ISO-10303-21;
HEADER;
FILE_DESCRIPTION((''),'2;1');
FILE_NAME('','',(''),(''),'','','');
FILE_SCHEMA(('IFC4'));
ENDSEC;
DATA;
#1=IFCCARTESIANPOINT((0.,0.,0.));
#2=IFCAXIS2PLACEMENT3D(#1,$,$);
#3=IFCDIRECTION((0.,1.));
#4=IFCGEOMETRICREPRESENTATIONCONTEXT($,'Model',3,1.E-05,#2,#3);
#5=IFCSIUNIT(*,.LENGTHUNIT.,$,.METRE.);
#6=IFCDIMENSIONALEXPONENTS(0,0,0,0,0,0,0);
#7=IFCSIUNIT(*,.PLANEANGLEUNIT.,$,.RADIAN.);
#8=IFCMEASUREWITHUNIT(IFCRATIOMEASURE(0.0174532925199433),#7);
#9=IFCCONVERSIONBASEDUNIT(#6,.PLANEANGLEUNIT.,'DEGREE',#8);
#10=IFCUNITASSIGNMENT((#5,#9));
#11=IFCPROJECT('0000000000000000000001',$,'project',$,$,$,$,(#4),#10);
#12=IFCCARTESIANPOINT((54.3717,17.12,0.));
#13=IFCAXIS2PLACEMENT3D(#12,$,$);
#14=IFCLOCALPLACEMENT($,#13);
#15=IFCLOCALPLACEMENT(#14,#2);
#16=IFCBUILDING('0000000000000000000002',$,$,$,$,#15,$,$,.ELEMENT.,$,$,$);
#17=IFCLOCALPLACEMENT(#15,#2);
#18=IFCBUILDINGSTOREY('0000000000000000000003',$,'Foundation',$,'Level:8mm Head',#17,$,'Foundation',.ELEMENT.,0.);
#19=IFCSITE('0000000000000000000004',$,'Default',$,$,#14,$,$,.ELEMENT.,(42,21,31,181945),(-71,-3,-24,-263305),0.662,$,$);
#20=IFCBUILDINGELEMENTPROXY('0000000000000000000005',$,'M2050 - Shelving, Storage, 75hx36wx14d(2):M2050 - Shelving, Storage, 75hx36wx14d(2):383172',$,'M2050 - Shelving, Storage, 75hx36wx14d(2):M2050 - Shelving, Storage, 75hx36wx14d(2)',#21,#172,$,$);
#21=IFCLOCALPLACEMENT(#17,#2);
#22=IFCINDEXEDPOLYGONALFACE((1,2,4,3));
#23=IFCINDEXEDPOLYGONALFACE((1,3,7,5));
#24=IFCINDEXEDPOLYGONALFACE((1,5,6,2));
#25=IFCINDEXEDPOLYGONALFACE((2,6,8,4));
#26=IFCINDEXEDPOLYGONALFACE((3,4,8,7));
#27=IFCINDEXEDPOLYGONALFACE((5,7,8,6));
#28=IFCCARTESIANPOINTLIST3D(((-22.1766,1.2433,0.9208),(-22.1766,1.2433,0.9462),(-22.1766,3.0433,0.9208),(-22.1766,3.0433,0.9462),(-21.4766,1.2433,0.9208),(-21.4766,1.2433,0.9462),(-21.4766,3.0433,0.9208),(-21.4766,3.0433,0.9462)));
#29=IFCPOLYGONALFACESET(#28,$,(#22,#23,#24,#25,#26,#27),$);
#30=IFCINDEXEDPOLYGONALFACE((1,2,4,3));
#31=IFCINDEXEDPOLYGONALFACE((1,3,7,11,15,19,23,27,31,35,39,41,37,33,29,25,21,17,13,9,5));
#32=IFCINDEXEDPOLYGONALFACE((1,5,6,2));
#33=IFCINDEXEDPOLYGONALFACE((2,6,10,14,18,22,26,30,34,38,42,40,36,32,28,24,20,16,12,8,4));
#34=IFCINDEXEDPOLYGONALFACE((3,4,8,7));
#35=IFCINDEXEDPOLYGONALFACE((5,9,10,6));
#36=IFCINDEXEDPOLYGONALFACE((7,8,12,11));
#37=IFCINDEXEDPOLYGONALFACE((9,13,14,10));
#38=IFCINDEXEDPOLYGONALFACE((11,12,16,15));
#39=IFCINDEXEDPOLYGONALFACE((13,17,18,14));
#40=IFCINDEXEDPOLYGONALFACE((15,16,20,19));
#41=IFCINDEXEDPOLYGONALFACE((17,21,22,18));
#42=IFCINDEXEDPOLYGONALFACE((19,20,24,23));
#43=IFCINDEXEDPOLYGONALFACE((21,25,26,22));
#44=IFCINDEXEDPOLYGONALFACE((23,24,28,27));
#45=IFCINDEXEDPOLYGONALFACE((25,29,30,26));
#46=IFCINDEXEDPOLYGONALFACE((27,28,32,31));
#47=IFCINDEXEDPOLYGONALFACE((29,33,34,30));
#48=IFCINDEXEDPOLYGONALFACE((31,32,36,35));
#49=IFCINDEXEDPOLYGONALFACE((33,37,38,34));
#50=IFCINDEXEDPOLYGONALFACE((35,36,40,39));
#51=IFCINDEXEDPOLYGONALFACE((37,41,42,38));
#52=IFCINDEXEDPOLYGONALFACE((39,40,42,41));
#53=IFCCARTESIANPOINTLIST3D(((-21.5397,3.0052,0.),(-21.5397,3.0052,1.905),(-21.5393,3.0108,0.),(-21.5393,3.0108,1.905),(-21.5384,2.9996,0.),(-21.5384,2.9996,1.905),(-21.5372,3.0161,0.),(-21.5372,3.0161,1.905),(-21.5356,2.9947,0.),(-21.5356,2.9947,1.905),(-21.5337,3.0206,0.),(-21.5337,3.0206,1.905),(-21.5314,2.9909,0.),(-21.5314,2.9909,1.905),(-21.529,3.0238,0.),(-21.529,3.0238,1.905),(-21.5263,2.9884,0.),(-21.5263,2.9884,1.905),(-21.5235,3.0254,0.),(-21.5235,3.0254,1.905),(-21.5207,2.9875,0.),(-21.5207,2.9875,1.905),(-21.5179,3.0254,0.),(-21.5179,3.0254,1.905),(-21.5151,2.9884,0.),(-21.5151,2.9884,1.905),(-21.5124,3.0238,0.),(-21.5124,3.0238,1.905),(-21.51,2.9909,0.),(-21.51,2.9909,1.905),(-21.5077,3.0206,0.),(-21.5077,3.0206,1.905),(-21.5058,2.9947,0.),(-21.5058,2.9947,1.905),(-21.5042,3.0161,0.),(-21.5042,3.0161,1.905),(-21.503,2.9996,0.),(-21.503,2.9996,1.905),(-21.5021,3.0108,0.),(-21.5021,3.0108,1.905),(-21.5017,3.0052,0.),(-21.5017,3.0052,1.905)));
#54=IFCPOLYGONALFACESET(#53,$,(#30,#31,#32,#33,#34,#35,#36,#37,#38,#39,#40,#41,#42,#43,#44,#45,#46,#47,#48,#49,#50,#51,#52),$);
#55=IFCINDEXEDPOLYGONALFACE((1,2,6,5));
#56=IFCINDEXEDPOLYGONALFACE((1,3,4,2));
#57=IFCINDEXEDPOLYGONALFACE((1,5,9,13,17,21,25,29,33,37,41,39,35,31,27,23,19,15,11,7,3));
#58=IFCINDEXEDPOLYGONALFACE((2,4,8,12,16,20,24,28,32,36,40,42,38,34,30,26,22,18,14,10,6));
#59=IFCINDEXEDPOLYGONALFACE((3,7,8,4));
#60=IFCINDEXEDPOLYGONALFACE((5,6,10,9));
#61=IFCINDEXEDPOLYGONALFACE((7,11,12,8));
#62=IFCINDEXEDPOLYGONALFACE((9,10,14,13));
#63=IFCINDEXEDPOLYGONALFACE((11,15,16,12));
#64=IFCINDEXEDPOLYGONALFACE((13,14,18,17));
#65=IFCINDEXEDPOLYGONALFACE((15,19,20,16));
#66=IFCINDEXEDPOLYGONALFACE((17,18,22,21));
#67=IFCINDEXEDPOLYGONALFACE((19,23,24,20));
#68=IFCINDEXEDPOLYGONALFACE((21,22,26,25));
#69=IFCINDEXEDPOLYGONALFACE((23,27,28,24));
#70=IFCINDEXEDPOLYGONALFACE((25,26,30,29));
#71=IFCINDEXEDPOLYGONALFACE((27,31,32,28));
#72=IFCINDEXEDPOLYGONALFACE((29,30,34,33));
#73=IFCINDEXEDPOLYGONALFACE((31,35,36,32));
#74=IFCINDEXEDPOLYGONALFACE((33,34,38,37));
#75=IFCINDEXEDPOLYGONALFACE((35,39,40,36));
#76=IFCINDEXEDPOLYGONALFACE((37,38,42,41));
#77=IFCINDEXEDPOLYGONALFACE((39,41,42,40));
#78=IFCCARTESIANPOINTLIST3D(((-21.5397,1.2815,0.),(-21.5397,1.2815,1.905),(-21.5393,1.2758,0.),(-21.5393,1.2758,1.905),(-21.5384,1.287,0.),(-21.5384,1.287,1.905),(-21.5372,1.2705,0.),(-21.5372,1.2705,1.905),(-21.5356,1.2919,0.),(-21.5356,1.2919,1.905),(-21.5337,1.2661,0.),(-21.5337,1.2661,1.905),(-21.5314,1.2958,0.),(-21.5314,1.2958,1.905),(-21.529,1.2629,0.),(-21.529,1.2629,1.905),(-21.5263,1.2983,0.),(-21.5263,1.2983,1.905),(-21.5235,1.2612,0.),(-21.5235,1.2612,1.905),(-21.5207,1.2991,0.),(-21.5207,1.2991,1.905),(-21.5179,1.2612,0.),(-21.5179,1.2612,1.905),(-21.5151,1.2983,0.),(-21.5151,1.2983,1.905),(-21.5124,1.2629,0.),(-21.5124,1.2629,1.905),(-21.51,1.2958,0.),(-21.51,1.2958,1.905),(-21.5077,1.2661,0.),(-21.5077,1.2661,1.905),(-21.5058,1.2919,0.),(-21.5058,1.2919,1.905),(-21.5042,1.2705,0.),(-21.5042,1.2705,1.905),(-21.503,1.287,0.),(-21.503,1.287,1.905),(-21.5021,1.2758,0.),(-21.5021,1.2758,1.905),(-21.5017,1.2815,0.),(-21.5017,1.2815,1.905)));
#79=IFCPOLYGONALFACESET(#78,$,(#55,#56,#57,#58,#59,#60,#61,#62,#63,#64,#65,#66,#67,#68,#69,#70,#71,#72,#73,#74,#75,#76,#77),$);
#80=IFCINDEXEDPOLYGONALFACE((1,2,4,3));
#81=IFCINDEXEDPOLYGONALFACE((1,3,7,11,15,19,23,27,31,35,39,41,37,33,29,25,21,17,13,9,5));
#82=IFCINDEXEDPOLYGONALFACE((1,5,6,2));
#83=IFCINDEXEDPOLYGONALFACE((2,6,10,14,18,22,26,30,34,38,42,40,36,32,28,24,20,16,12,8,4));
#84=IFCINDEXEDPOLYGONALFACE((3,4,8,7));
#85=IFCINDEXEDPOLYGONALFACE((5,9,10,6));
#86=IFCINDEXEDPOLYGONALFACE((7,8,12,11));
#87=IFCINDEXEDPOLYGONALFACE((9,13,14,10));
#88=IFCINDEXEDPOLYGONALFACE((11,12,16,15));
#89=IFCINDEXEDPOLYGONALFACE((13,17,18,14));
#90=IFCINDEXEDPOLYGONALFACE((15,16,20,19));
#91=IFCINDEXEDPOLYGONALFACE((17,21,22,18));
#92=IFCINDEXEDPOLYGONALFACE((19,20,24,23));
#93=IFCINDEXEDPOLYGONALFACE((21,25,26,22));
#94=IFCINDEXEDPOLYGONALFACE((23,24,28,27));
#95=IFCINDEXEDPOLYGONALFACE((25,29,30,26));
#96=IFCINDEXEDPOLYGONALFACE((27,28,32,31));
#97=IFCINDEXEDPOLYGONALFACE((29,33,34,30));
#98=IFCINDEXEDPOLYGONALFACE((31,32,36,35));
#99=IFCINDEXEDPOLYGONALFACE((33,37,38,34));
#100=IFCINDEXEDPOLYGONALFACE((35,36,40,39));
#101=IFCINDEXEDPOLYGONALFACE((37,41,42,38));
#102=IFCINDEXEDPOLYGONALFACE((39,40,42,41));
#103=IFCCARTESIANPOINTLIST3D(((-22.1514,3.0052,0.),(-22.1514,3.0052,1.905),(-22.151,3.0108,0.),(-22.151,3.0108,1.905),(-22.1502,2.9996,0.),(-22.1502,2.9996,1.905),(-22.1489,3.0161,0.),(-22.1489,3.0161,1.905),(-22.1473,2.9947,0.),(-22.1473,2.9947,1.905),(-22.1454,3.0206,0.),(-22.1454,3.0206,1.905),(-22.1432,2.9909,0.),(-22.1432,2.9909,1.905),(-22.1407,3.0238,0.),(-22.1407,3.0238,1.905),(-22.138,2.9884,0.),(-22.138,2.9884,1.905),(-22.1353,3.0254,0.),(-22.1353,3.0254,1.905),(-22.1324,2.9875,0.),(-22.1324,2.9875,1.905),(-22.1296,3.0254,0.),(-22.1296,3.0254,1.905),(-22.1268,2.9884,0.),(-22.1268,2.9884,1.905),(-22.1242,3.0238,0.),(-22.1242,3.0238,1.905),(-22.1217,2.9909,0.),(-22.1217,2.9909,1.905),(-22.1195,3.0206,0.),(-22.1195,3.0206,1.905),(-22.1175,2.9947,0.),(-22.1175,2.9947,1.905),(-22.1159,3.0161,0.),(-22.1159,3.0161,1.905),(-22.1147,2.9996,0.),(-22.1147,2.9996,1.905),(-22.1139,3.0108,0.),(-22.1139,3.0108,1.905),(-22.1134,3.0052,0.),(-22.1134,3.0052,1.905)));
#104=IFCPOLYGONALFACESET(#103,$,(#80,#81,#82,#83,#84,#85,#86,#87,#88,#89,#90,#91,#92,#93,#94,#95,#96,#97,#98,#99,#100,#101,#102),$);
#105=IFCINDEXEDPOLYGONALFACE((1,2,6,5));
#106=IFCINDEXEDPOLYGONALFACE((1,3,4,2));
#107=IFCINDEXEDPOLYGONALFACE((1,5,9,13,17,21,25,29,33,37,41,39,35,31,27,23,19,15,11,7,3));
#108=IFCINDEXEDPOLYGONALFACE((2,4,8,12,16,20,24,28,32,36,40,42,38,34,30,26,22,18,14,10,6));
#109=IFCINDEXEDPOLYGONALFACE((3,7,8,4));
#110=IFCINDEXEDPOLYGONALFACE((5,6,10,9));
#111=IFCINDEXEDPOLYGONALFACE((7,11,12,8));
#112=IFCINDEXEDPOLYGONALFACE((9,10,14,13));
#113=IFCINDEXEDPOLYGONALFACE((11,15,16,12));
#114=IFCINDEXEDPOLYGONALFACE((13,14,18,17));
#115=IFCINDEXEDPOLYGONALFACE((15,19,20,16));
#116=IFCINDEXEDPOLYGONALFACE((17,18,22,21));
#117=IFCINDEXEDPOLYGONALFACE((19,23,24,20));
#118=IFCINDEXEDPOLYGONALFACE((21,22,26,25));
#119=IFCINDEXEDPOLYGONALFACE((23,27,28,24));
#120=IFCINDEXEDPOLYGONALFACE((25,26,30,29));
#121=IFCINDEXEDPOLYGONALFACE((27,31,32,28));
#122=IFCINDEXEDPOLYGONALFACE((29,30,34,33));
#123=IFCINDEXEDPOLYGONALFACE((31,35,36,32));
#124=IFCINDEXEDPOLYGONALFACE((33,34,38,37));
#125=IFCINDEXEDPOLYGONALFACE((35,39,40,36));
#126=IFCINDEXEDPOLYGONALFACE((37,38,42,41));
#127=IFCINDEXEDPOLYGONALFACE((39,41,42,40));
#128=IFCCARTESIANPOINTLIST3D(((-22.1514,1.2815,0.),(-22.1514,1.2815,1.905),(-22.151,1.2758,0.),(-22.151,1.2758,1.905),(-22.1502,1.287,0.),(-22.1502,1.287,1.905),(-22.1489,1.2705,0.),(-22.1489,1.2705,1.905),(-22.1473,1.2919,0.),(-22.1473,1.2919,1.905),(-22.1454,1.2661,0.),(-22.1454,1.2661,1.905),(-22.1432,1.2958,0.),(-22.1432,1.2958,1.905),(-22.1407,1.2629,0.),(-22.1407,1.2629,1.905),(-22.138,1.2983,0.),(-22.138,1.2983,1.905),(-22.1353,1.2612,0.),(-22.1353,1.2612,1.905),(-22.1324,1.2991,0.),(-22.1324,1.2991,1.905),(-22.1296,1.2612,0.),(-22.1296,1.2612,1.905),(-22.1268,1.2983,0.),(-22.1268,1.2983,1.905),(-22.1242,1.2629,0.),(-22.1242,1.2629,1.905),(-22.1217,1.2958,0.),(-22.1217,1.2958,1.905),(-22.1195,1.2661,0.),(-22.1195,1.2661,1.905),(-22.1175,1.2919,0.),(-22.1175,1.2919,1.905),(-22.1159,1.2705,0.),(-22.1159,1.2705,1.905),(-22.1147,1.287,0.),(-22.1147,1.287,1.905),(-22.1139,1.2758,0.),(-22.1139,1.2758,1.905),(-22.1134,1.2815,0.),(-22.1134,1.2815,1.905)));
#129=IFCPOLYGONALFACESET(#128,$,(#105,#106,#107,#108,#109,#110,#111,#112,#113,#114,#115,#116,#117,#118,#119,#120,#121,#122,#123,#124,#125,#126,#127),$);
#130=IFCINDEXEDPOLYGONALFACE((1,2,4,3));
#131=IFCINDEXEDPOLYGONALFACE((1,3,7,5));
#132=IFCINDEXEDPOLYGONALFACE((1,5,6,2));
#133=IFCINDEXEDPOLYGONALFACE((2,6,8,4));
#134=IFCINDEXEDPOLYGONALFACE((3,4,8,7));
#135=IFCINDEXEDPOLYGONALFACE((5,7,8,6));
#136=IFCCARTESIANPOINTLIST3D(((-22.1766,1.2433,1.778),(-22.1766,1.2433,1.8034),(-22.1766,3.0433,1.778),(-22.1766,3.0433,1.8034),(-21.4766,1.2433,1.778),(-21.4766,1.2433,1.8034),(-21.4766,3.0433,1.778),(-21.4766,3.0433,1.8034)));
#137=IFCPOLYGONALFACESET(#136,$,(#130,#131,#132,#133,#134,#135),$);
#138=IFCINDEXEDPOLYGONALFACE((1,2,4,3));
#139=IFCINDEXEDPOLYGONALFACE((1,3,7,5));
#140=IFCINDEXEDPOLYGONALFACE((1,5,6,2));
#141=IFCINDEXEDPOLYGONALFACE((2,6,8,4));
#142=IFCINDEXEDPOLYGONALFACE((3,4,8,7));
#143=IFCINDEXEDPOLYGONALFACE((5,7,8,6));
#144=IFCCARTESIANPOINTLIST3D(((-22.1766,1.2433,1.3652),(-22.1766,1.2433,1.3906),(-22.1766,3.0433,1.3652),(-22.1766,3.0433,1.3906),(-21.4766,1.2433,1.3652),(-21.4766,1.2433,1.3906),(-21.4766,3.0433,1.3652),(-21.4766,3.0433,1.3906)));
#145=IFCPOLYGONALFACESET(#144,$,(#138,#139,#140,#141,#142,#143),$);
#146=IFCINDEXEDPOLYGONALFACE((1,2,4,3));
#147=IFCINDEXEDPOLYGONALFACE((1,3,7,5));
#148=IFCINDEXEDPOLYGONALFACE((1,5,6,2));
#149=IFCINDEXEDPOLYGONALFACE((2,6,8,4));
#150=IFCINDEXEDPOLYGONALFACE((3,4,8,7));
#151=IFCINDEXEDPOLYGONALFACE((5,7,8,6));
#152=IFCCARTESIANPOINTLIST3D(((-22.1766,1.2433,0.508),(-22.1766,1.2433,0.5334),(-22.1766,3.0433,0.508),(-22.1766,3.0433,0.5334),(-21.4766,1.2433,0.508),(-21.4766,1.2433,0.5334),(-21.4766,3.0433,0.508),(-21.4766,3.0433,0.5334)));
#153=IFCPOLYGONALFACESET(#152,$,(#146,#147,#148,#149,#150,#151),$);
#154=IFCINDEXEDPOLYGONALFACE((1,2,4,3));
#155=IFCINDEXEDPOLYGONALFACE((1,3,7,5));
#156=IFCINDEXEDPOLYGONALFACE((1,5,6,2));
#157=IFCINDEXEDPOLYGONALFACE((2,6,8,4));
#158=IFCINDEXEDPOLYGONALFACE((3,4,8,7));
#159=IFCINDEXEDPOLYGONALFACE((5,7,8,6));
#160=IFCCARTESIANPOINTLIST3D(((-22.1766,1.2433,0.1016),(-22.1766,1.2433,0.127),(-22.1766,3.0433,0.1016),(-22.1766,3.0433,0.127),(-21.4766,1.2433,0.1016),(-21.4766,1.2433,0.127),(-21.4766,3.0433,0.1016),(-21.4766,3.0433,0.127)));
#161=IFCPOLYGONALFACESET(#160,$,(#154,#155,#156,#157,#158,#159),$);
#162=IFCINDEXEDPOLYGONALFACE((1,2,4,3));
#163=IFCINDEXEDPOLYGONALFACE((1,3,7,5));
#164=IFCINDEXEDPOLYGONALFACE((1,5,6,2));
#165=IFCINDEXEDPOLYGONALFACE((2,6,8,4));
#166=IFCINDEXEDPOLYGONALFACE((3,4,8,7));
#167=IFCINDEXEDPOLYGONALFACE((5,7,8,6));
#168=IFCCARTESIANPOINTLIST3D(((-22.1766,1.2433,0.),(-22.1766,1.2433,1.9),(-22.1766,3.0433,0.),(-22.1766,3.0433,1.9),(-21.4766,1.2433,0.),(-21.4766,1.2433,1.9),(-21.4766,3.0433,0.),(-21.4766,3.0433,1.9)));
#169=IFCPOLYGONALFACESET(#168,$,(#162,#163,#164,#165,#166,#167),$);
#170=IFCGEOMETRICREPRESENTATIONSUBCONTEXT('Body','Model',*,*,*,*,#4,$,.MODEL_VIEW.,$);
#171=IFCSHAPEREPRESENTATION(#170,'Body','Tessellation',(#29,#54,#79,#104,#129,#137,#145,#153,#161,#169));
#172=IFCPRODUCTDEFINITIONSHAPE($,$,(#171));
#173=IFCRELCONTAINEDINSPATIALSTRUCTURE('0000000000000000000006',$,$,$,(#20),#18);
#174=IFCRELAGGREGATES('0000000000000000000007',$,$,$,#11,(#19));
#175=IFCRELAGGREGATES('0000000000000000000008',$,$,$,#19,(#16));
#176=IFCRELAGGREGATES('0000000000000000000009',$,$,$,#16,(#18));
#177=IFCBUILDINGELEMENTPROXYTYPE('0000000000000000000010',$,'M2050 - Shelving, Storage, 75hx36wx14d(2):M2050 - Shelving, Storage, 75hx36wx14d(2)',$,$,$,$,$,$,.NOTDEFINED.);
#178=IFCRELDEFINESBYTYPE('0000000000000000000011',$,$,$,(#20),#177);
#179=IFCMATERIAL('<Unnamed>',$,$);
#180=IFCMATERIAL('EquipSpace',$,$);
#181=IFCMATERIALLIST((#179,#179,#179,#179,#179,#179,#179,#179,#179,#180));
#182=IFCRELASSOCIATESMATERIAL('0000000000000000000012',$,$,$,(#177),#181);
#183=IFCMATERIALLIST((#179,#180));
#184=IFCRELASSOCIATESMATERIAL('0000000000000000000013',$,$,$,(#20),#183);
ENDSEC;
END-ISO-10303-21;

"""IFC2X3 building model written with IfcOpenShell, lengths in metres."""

from ifc_helpers import new_model, entity, si_unit, converted_unit, direction, frame, frame_2d, origin, origin_2d_with_axis, place, context, subcontext, project, spatial, rectangle, circle, extrude, source, transform, mapped, material, material_list, type_object, type_shapes, element, save


model = new_model("IFC2X3")

# Units and contexts
model_context = context("Model", 3, precision=1e-05, world=origin(), true_north=direction((0.0, 1.0)))
body_context = subcontext(model_context, "Body", "Model", "MODEL_VIEW")
ifc_project = project(units=[si_unit("LENGTHUNIT", "METRE"), converted_unit("PLANEANGLEUNIT", "DEGREE", entity("IfcRatioMeasure", 0.0174532925199433), si_unit("PLANEANGLEUNIT", "RADIAN"), dimensions=[0, 0, 0, 0, 0, 0, 0])], contexts=[model_context])

# Site, building, storey
site_placement = place(None, frame((54.3717, 17.12, 0.0)))
site = spatial("IfcSite", under=ifc_project, at=site_placement, Name="Default", CompositionType="ELEMENT", RefLatitude=(42, 21, 31, 181945), RefLongitude=(-71, -3, -24, -263305), RefElevation=0.662)
building_placement = place(site_placement, origin())
building = spatial("IfcBuilding", under=site, at=building_placement, CompositionType="ELEMENT")
storey_placement = place(building_placement, origin())
storey = spatial("IfcBuildingStorey", under=building, at=storey_placement, Name="Foundation", ObjectType="Level:8mm Head", LongName="Foundation", CompositionType="ELEMENT", Elevation=0.0)

# Building element proxy
ifc_material_1 = material(Name="<Unnamed>")
ifc_material_2 = material(Name="EquipSpace")
ifc_material_list_1 = material_list([ifc_material_1, ifc_material_2])
ifc_material_list_2 = material_list([ifc_material_1, ifc_material_1, ifc_material_1, ifc_material_1, ifc_material_1, ifc_material_1, ifc_material_1, ifc_material_1, ifc_material_1, ifc_material_2])
building_element_proxy_type = type_object("IfcBuildingElementProxyType", Name="M2050 - Shelving, Storage, 75hx36wx14d(2):M2050 - Shelving, Storage, 75hx36wx14d(2)", PredefinedType="NOTDEFINED", material=ifc_material_list_2)
shared_shape = source(origin(), body_context, "Body", "SweptSolid", [
    extrude(rectangle(XDim=1.8, YDim=0.7, at=origin_2d_with_axis()), frame((0.0, 0.0, 0.9207), z_axis=(0.0, 0.0, 1.0), x_axis=(-1.0, 0.0, 0.0)), (0.0, 0.0, 1.0), 0.0254),
    extrude(circle(Radius=0.0191, at=origin_2d_with_axis()), frame((0.8633, -0.3059, 0.0), z_axis=(0.0, 0.0, 1.0), x_axis=(-1.0, 0.0, 0.0)), (0.0, 0.0, 1.0), 1.905),
    extrude(circle(Radius=0.0191, at=origin_2d_with_axis()), frame((-0.8633, -0.3059, 0.0)), (0.0, 0.0, 1.0), 1.905),
    extrude(circle(Radius=0.0191, at=origin_2d_with_axis()), frame((0.8633, 0.3059, 0.0), z_axis=(0.0, 0.0, 1.0), x_axis=(-1.0, 0.0, 0.0)), (0.0, 0.0, 1.0), 1.905),
    extrude(circle(Radius=0.0191, at=origin_2d_with_axis()), frame((-0.8633, 0.3059, 0.0)), (0.0, 0.0, 1.0), 1.905),
    extrude(rectangle(XDim=1.8, YDim=0.7, at=origin_2d_with_axis()), frame((0.0, 0.0, 1.778), z_axis=(0.0, 0.0, 1.0), x_axis=(-1.0, 0.0, 0.0)), (0.0, 0.0, 1.0), 0.0254),
    extrude(rectangle(XDim=1.8, YDim=0.7, at=origin_2d_with_axis()), frame((0.0, 0.0, 1.3653), z_axis=(0.0, 0.0, 1.0), x_axis=(-1.0, 0.0, 0.0)), (0.0, 0.0, 1.0), 0.0254),
    extrude(rectangle(XDim=1.8, YDim=0.7, at=origin_2d_with_axis()), frame((0.0, 0.0, 0.508), z_axis=(0.0, 0.0, 1.0), x_axis=(-1.0, 0.0, 0.0)), (0.0, 0.0, 1.0), 0.0254),
    extrude(rectangle(XDim=1.8, YDim=0.7, at=origin_2d_with_axis()), frame((0.0, 0.0, 0.1016), z_axis=(0.0, 0.0, 1.0), x_axis=(-1.0, 0.0, 0.0)), (0.0, 0.0, 1.0), 0.0254),
    extrude(rectangle(XDim=0.7, YDim=1.8, at=frame_2d((0.0, 0.18), x_axis=(1.0, 0.0))), frame((-0.18, 0.0, 0.0), z_axis=(0.0, 0.0, 1.0), x_axis=(0.0, -1.0, 0.0)), (0.0, 0.0, 1.0), 1.9),
])
type_shapes(building_element_proxy_type, [shared_shape])
proxy_1_placement = place(storey_placement, frame((-21.8266, 2.1433, 0.0), z_axis=(0.0, 0.0, 1.0), x_axis=(0.0, 1.0, 0.0)))
element("IfcBuildingElementProxy", 1, at=proxy_1_placement, inside=storey, type_object=building_element_proxy_type, material=ifc_material_list_1, Name="M2050 - Shelving, Storage, 75hx36wx14d(2):M2050 - Shelving, Storage, 75hx36wx14d(2):383172", ObjectType="M2050 - Shelving, Storage, 75hx36wx14d(2):M2050 - Shelving, Storage, 75hx36wx14d(2)", context=body_context, shape_type="MappedRepresentation", body=[
    mapped(shared_shape, transform((0.0, 0.0, 0.0), scale=1.0)),
])

save(model, "model.ifc")
